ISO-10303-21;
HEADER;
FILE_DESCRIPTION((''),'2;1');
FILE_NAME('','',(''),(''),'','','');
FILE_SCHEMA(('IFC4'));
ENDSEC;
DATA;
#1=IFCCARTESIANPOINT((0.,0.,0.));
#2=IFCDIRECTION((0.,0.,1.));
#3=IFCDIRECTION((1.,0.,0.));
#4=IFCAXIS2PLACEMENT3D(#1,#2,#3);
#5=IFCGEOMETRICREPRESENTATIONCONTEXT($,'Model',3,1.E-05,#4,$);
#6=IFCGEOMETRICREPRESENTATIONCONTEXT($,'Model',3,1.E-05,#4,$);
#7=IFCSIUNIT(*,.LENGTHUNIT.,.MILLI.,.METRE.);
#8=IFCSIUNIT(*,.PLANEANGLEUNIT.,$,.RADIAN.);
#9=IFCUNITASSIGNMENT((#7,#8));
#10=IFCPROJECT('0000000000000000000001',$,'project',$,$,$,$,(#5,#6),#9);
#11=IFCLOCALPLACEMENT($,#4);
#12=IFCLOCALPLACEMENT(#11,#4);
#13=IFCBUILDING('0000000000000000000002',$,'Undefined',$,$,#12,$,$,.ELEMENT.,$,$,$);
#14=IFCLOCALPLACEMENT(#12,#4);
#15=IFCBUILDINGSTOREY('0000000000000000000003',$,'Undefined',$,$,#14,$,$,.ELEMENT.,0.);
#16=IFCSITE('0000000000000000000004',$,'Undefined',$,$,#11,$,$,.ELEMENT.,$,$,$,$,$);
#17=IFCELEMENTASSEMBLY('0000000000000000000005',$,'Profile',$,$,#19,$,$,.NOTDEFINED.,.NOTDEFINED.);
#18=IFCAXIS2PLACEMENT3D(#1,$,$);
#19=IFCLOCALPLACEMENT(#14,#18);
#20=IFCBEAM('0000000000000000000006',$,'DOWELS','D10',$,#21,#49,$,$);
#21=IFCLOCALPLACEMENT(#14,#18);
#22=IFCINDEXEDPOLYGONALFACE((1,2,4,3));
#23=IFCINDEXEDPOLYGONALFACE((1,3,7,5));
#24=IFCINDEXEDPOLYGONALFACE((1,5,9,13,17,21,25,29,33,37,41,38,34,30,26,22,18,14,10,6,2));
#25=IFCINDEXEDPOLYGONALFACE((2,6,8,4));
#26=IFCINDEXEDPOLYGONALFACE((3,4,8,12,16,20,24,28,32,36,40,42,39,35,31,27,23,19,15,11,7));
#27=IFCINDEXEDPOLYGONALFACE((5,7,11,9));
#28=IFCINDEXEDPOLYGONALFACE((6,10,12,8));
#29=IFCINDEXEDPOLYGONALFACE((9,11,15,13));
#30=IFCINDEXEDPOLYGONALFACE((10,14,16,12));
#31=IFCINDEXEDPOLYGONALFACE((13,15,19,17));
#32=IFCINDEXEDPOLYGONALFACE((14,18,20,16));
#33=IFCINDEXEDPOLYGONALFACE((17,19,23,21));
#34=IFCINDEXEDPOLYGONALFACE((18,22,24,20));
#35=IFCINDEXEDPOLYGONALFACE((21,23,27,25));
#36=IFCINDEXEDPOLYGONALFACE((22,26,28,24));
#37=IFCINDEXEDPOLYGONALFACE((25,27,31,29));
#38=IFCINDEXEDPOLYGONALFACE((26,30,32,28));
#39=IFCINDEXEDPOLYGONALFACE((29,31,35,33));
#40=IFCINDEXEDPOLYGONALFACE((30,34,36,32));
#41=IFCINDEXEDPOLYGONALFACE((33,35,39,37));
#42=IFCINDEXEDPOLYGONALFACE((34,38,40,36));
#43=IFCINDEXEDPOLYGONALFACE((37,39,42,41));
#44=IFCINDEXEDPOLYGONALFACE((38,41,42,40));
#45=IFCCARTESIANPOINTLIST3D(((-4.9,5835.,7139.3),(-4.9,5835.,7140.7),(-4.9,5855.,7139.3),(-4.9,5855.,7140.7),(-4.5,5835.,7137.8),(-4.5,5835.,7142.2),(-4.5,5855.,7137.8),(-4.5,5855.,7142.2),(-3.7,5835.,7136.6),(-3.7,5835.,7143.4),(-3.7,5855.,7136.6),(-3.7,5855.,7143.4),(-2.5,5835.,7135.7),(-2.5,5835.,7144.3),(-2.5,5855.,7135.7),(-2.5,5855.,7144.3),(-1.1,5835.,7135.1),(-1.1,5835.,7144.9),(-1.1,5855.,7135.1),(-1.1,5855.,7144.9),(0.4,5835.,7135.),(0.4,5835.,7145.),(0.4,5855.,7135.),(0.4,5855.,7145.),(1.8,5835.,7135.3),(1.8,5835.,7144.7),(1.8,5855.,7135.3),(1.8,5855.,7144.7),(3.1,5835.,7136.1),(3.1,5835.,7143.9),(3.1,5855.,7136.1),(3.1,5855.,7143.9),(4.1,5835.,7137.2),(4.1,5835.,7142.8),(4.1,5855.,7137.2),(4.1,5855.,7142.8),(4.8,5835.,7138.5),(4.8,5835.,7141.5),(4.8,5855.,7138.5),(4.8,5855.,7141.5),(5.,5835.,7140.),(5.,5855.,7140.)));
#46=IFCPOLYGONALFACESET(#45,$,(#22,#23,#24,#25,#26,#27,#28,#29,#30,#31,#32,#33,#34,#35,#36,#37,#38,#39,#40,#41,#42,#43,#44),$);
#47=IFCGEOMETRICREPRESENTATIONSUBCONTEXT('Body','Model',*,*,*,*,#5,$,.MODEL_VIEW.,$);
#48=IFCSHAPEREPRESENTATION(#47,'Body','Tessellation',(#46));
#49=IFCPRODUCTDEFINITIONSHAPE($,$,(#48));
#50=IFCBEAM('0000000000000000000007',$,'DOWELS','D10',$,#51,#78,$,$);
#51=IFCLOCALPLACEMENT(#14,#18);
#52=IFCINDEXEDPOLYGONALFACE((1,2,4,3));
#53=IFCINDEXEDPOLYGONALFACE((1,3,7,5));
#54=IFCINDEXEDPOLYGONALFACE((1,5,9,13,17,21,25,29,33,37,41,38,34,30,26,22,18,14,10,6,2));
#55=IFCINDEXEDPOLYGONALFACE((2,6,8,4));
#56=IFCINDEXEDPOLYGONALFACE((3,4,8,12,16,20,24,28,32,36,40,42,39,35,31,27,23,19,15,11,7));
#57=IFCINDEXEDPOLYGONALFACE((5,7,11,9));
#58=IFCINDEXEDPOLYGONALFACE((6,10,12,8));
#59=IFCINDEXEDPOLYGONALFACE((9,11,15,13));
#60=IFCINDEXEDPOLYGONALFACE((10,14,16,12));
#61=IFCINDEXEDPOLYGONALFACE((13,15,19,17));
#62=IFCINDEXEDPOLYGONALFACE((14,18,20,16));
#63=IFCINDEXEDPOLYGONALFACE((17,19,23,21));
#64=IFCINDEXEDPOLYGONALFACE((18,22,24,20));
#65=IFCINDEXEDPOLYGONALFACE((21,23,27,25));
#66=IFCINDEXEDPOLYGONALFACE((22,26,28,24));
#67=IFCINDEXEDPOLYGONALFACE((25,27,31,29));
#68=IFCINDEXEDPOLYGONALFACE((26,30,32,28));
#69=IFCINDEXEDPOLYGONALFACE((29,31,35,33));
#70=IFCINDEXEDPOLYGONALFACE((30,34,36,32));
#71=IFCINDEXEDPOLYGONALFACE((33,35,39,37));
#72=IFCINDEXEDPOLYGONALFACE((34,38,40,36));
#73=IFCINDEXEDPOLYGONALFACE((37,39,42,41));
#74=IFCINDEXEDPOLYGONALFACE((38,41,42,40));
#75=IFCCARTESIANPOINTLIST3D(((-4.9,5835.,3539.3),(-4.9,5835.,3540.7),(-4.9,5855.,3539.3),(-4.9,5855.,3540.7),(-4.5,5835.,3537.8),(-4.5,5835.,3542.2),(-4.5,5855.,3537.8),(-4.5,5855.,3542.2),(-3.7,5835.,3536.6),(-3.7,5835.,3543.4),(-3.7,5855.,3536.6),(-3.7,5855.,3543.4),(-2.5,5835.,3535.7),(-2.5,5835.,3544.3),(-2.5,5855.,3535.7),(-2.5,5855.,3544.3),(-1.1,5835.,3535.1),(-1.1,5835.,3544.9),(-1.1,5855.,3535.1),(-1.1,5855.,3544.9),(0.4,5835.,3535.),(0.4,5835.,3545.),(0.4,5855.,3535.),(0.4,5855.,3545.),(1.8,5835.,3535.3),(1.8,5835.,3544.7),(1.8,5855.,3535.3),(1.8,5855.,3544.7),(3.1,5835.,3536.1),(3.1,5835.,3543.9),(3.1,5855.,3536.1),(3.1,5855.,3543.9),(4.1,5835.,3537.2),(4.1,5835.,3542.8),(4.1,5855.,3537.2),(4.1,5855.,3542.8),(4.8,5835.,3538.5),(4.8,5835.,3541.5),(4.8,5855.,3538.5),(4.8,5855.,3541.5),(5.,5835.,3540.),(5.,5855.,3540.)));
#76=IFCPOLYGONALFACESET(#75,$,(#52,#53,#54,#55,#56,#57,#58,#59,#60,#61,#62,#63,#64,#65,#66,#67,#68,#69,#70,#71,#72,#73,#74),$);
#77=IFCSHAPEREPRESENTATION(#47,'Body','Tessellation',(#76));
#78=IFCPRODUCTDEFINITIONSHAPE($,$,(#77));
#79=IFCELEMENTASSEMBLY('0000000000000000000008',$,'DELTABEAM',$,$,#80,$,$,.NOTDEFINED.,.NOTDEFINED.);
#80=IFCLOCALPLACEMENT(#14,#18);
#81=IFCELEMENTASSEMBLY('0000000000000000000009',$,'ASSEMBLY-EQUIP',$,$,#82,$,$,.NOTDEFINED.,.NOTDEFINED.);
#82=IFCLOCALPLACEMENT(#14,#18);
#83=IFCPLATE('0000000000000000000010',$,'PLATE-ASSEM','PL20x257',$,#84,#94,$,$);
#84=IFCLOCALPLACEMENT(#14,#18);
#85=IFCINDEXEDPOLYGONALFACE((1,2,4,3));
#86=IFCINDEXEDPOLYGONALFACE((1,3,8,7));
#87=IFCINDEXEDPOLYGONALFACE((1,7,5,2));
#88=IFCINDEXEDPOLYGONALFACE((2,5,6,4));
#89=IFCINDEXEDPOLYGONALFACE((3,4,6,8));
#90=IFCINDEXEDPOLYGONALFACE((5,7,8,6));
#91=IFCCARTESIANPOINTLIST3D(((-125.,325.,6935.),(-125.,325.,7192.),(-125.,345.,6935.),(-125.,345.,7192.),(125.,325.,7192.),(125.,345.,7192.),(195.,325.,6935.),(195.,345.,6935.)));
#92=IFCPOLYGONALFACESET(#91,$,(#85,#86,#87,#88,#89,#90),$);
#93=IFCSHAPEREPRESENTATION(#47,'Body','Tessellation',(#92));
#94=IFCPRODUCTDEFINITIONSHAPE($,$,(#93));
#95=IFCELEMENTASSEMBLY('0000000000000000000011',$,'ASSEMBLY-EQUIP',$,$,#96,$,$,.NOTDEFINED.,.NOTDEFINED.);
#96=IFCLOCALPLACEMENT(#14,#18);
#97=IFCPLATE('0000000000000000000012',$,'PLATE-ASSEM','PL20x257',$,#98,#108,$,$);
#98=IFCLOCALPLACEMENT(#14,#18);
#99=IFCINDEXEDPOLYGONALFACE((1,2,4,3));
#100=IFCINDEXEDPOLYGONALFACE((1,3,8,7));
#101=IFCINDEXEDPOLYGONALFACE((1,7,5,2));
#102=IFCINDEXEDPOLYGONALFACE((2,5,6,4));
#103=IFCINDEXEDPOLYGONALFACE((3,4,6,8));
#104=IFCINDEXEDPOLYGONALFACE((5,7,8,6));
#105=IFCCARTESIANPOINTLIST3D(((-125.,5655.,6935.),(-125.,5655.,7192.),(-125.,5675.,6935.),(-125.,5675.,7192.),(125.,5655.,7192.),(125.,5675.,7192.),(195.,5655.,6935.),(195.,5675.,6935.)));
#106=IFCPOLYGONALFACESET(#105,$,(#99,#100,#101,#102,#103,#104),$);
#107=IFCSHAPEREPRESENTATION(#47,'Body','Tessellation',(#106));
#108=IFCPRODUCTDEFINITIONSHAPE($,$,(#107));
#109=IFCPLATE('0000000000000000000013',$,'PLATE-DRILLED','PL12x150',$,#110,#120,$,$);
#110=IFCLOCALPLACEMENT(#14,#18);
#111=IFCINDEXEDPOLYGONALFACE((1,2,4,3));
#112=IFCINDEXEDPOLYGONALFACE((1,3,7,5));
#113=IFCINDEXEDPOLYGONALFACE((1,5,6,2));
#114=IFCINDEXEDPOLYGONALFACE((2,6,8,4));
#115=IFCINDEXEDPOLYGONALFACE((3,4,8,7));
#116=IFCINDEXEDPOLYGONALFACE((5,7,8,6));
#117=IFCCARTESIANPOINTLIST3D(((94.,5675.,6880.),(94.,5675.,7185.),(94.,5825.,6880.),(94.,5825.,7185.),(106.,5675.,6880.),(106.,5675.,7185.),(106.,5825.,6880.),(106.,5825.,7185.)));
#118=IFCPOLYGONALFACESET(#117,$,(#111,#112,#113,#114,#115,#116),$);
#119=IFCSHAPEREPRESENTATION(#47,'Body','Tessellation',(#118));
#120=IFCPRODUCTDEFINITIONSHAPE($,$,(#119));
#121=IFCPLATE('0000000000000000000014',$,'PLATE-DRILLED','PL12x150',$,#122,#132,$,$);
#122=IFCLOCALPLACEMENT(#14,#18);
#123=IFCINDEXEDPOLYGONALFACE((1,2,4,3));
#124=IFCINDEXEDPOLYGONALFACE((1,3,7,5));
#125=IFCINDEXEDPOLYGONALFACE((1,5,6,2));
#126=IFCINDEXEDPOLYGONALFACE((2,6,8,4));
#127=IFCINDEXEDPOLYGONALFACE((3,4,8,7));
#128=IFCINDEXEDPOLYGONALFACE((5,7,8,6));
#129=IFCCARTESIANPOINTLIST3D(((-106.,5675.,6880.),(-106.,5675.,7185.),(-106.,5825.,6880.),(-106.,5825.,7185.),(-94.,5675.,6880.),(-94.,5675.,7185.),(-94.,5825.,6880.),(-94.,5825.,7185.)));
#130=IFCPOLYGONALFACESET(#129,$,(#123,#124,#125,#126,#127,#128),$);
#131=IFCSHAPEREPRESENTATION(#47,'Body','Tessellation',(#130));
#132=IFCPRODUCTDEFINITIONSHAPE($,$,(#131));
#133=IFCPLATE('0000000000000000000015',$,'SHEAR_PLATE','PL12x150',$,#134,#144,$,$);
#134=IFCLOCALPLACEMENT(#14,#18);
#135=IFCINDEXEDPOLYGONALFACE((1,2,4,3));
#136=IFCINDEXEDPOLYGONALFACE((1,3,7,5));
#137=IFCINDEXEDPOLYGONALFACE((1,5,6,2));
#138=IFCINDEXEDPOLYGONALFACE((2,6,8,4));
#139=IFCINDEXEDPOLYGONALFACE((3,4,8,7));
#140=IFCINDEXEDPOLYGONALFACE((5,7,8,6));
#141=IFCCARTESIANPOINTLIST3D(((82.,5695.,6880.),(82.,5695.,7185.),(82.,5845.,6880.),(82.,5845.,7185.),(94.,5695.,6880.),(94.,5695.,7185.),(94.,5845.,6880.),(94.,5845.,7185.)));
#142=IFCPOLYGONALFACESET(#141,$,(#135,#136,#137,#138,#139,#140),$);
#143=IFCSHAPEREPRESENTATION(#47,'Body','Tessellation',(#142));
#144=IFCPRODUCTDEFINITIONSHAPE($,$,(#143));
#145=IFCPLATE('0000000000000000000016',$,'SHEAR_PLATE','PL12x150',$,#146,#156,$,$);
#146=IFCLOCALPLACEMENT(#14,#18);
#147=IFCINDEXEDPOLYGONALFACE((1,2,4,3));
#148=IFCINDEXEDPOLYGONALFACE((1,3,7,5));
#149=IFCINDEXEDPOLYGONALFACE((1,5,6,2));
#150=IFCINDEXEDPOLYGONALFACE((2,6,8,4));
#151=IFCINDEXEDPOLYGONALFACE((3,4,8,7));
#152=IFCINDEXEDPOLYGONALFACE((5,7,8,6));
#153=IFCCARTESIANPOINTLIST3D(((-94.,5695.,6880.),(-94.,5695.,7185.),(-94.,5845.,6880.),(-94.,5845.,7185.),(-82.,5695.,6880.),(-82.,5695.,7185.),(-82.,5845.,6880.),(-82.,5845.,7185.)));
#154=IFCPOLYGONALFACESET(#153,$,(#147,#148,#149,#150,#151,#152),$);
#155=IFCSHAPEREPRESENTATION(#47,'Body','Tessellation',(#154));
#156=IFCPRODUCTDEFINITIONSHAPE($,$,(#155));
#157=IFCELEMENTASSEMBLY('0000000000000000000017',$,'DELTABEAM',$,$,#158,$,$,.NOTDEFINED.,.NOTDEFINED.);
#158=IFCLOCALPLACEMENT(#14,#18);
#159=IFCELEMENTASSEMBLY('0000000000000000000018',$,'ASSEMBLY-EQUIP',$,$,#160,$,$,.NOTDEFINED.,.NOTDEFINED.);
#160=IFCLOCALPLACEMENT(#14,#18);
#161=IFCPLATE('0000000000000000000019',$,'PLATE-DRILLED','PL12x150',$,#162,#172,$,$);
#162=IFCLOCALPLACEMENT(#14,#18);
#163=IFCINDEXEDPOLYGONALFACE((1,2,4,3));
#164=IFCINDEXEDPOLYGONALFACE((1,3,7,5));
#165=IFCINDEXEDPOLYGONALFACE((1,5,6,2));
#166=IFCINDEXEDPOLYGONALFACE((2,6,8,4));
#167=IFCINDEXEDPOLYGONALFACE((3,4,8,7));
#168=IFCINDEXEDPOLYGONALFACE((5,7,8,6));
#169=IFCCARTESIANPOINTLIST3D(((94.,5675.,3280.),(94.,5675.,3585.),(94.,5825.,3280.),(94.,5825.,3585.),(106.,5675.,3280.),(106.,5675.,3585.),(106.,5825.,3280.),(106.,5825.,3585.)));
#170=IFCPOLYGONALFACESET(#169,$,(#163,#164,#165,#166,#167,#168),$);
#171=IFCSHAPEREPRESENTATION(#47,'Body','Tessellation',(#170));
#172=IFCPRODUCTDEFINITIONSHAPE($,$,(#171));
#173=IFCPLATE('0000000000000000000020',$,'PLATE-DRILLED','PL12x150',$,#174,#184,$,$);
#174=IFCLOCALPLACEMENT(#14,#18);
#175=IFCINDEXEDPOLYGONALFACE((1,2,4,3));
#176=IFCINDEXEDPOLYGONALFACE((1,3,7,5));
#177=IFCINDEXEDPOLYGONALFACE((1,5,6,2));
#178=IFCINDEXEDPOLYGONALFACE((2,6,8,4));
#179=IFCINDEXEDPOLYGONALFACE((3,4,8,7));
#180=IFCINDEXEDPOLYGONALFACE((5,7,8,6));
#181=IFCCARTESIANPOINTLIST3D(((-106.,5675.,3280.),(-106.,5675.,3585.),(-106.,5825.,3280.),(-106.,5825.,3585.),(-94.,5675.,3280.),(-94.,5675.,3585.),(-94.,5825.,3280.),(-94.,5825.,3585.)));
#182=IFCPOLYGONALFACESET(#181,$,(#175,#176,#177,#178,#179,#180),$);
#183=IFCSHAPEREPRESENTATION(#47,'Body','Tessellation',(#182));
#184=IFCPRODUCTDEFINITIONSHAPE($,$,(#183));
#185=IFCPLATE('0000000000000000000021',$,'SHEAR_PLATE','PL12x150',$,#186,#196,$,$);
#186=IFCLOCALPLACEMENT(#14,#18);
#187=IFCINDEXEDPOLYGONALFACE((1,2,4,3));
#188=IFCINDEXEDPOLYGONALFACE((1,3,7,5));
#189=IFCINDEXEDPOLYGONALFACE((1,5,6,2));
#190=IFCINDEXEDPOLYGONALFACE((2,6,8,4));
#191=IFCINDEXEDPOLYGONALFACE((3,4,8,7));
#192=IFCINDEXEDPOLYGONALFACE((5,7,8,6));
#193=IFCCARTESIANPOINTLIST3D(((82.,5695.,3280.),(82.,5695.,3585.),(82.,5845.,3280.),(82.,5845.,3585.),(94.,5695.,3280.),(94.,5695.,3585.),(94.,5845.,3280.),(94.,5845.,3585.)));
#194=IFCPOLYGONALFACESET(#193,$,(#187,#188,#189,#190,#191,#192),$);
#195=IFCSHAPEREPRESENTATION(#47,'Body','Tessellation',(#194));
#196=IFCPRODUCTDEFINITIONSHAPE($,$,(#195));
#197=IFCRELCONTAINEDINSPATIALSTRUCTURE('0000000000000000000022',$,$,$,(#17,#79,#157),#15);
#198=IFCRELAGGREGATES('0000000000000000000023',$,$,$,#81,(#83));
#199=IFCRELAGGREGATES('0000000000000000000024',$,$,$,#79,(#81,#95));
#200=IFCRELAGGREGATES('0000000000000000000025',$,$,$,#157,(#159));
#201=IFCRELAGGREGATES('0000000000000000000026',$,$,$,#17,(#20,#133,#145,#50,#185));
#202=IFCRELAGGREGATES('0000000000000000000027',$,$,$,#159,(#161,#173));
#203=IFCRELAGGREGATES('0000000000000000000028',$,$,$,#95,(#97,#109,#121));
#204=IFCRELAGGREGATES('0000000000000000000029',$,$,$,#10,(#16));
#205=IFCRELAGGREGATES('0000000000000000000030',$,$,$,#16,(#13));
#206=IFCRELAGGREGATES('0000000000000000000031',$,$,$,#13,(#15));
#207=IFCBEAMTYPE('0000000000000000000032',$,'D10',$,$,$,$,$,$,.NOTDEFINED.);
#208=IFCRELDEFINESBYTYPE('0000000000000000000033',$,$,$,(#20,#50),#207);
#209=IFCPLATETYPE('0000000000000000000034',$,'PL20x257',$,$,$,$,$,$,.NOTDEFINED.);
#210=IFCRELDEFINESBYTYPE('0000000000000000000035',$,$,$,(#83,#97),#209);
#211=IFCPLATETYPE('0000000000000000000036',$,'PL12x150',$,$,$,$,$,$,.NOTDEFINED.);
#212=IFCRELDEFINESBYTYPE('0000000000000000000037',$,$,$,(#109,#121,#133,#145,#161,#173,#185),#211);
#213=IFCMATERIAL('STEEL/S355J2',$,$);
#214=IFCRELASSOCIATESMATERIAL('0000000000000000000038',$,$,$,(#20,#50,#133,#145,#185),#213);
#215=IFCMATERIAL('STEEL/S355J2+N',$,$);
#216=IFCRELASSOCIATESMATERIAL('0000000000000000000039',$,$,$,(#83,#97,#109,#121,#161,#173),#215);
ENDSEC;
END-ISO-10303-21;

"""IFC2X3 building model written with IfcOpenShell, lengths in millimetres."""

from ifc_helpers import new_model, si_unit, frame, origin_with_axes, origin_2d_with_axis, place, context, subcontext, project, spatial, polyline, circle, outline, extrude, material, type_object, element, aggregate, save


model = new_model("IFC2X3")

# Units and contexts
model_context_1 = context("Model", 3, precision=1e-05, world=origin_with_axes())
model_context_2 = context("Model", 3, precision=1e-05, world=origin_with_axes())
body_context = subcontext(model_context_1, "Body", "Model", "MODEL_VIEW")
ifc_project = project(units=[si_unit("LENGTHUNIT", "METRE", prefix="MILLI"), si_unit("PLANEANGLEUNIT", "RADIAN")], contexts=[model_context_1, model_context_2])

# Site, building, storey
site_placement = place(None, origin_with_axes())
site = spatial("IfcSite", under=ifc_project, at=site_placement, Name="Undefined", CompositionType="ELEMENT")
building_placement = place(site_placement, origin_with_axes())
building = spatial("IfcBuilding", under=site, at=building_placement, Name="Undefined", CompositionType="ELEMENT")
storey_placement = place(building_placement, origin_with_axes())
storey = spatial("IfcBuildingStorey", under=building, at=storey_placement, Name="Undefined", CompositionType="ELEMENT", Elevation=0.0)

# Element assembly, beams
assembly_1_placement = place(storey_placement, origin_with_axes())
assembly_1 = element("IfcElementAssembly", 1, at=assembly_1_placement, inside=storey, Name="Profile", AssemblyPlace="NOTDEFINED", PredefinedType="NOTDEFINED")
ifc_material_1 = material(Name="STEEL/S355J2")
beam_type_1 = type_object("IfcBeamType", Name="D10", PredefinedType="NOTDEFINED")
beam_1_placement = place(assembly_1_placement, frame((0.0, 5835.0, 7140.0), z_axis=(0.0, 0.0, 1.0), x_axis=(0.0, 1.0, 0.0)))
beam_1 = element("IfcBeam", 2, at=beam_1_placement, type_object=beam_type_1, material=ifc_material_1, Name="DOWELS", Description="D10", context=body_context, shape_type="SweptSolid", body=[
    extrude(circle(Radius=5.0, at=origin_2d_with_axis()), frame((20.0, 0.0, 0.0), z_axis=(-1.0, 0.0, 0.0), x_axis=(0.0, -1.0, 0.0)), (0.0, 0.0, 1.0), 20.0),
])
beam_2_placement = place(assembly_1_placement, frame((0.0, 5835.0, 3540.0), z_axis=(0.0, 0.0, 1.0), x_axis=(0.0, 1.0, 0.0)))
beam_2 = element("IfcBeam", 3, at=beam_2_placement, type_object=beam_type_1, material=ifc_material_1, Name="DOWELS", Description="D10", context=body_context, shape_type="SweptSolid", body=[
    extrude(circle(Radius=5.0, at=origin_2d_with_axis()), frame((20.0, 0.0, 0.0), z_axis=(-1.0, 0.0, 0.0), x_axis=(0.0, -1.0, 0.0)), (0.0, 0.0, 1.0), 20.0),
])

# Element assemblies, plates
assembly_2_placement = place(storey_placement, origin_with_axes())
assembly_2 = element("IfcElementAssembly", 4, at=assembly_2_placement, inside=storey, Name="DELTABEAM", AssemblyPlace="NOTDEFINED", PredefinedType="NOTDEFINED")
assembly_3_placement = place(assembly_2_placement, origin_with_axes())
assembly_3 = element("IfcElementAssembly", 5, at=assembly_3_placement, Name="ASSEMBLY-EQUIP", AssemblyPlace="NOTDEFINED", PredefinedType="NOTDEFINED")
ifc_material_2 = material(Name="STEEL/S355J2+N")
plate_type_1 = type_object("IfcPlateType", Name="PL20x257", PredefinedType="NOTDEFINED")
plate_1_placement = place(assembly_3_placement, frame((195.0, 335.0, 6935.0), z_axis=(0.0, 1.0, 0.0), x_axis=(-1.0, 0.0, 0.0)))
plate_1 = element("IfcPlate", 6, at=plate_1_placement, type_object=plate_type_1, material=ifc_material_2, Name="PLATE-ASSEM", Description="PL20x257", context=body_context, shape_type="SweptSolid", body=[
    extrude(outline(polyline([(0.0, 0.0), (320.0, 0.0), (320.0, 257.0), (70.0, 257.0), (0.0, 0.0)])), frame((0.0, 0.0, -10.0), z_axis=(0.0, 0.0, 1.0), x_axis=(1.0, 0.0, 0.0)), (0.0, 0.0, 1.0), 20.0),
])
aggregate(assembly_3, [plate_1])
assembly_4_placement = place(assembly_2_placement, origin_with_axes())
assembly_4 = element("IfcElementAssembly", 7, at=assembly_4_placement, Name="ASSEMBLY-EQUIP", AssemblyPlace="NOTDEFINED", PredefinedType="NOTDEFINED")
aggregate(assembly_2, [assembly_3, assembly_4])
plate_2_placement = place(assembly_4_placement, frame((-125.0, 5665.0, 6935.0), z_axis=(0.0, -1.0, 0.0), x_axis=(1.0, 0.0, 0.0)))
plate_2 = element("IfcPlate", 8, at=plate_2_placement, type_object=plate_type_1, material=ifc_material_2, Name="PLATE-ASSEM", Description="PL20x257", context=body_context, shape_type="SweptSolid", body=[
    extrude(outline(polyline([(0.0, 0.0), (320.0, 0.0), (250.0, 257.0), (0.0, 257.0), (0.0, 0.0)])), frame((0.0, 0.0, -10.0), z_axis=(0.0, 0.0, 1.0), x_axis=(1.0, 0.0, 0.0)), (0.0, 0.0, 1.0), 20.0),
])
plate_type_2 = type_object("IfcPlateType", Name="PL12x150", PredefinedType="NOTDEFINED")
plate_3_placement = place(assembly_4_placement, frame((100.0, 5675.0, 7185.0), z_axis=(-1.0, 0.0, 0.0), x_axis=(0.0, 1.0, 0.0)))
plate_3 = element("IfcPlate", 9, at=plate_3_placement, type_object=plate_type_2, material=ifc_material_2, Name="PLATE-DRILLED", Description="PL12x150", context=body_context, shape_type="SweptSolid", body=[
    extrude(outline(polyline([(0.0, 0.0), (150.0, 0.0), (150.0, 0.0), (150.0, 305.0), (150.0, 305.0), (0.0, 305.0), (0.0, 305.0), (0.0, 0.0)])), frame((0.0, 0.0, -6.0), z_axis=(0.0, 0.0, 1.0), x_axis=(1.0, 0.0, 0.0)), (0.0, 0.0, 1.0), 12.0),
])
plate_4_placement = place(assembly_4_placement, frame((-100.0, 5675.0, 7185.0), z_axis=(-1.0, 0.0, 0.0), x_axis=(0.0, 1.0, 0.0)))
plate_4 = element("IfcPlate", 10, at=plate_4_placement, type_object=plate_type_2, material=ifc_material_2, Name="PLATE-DRILLED", Description="PL12x150", context=body_context, shape_type="SweptSolid", body=[
    extrude(outline(polyline([(0.0, 0.0), (150.0, 0.0), (150.0, 0.0), (150.0, 305.0), (150.0, 305.0), (0.0, 305.0), (0.0, 305.0), (0.0, 0.0)])), frame((0.0, 0.0, -6.0), z_axis=(0.0, 0.0, 1.0), x_axis=(1.0, 0.0, 0.0)), (0.0, 0.0, 1.0), 12.0),
])

# Plates
plate_5_placement = place(assembly_1_placement, frame((88.0, 5845.0, 7185.0), z_axis=(1.0, 0.0, 0.0), x_axis=(0.0, -1.0, 0.0)))
plate_5 = element("IfcPlate", 11, at=plate_5_placement, type_object=plate_type_2, material=ifc_material_1, Name="SHEAR_PLATE", Description="PL12x150", context=body_context, shape_type="SweptSolid", body=[
    extrude(outline(polyline([(0.0, 0.0), (150.0, 0.0), (150.0, 0.0), (150.0, 305.0), (150.0, 305.0), (0.0, 305.0), (0.0, 305.0), (0.0, 0.0)])), frame((0.0, 0.0, -6.0), z_axis=(0.0, 0.0, 1.0), x_axis=(1.0, 0.0, 0.0)), (0.0, 0.0, 1.0), 12.0),
])
plate_6_placement = place(assembly_1_placement, frame((-88.0, 5845.0, 7185.0), z_axis=(1.0, 0.0, 0.0), x_axis=(0.0, -1.0, 0.0)))
plate_6 = element("IfcPlate", 12, at=plate_6_placement, type_object=plate_type_2, material=ifc_material_1, Name="SHEAR_PLATE", Description="PL12x150", context=body_context, shape_type="SweptSolid", body=[
    extrude(outline(polyline([(0.0, 0.0), (150.0, 0.0), (150.0, 0.0), (150.0, 305.0), (150.0, 305.0), (0.0, 305.0), (0.0, 305.0), (0.0, 0.0)])), frame((0.0, 0.0, -6.0), z_axis=(0.0, 0.0, 1.0), x_axis=(1.0, 0.0, 0.0)), (0.0, 0.0, 1.0), 12.0),
])

# Element assemblies, plates
assembly_5_placement = place(storey_placement, origin_with_axes())
assembly_5 = element("IfcElementAssembly", 13, at=assembly_5_placement, inside=storey, Name="DELTABEAM", AssemblyPlace="NOTDEFINED", PredefinedType="NOTDEFINED")
assembly_6_placement = place(assembly_5_placement, origin_with_axes())
assembly_6 = element("IfcElementAssembly", 14, at=assembly_6_placement, Name="ASSEMBLY-EQUIP", AssemblyPlace="NOTDEFINED", PredefinedType="NOTDEFINED")
aggregate(assembly_5, [assembly_6])
plate_7_placement = place(assembly_6_placement, frame((100.0, 5675.0, 3585.0), z_axis=(-1.0, 0.0, 0.0), x_axis=(0.0, 1.0, 0.0)))
plate_7 = element("IfcPlate", 15, at=plate_7_placement, type_object=plate_type_2, material=ifc_material_2, Name="PLATE-DRILLED", Description="PL12x150", context=body_context, shape_type="SweptSolid", body=[
    extrude(outline(polyline([(0.0, 0.0), (150.0, 0.0), (150.0, 0.0), (150.0, 305.0), (150.0, 305.0), (0.0, 305.0), (0.0, 305.0), (0.0, 0.0)])), frame((0.0, 0.0, -6.0), z_axis=(0.0, 0.0, 1.0), x_axis=(1.0, 0.0, 0.0)), (0.0, 0.0, 1.0), 12.0),
])
plate_8_placement = place(assembly_6_placement, frame((-100.0, 5675.0, 3585.0), z_axis=(-1.0, 0.0, 0.0), x_axis=(0.0, 1.0, 0.0)))
plate_8 = element("IfcPlate", 16, at=plate_8_placement, type_object=plate_type_2, material=ifc_material_2, Name="PLATE-DRILLED", Description="PL12x150", context=body_context, shape_type="SweptSolid", body=[
    extrude(outline(polyline([(0.0, 0.0), (150.0, 0.0), (150.0, 0.0), (150.0, 305.0), (150.0, 305.0), (0.0, 305.0), (0.0, 305.0), (0.0, 0.0)])), frame((0.0, 0.0, -6.0), z_axis=(0.0, 0.0, 1.0), x_axis=(1.0, 0.0, 0.0)), (0.0, 0.0, 1.0), 12.0),
])

# Plate
plate_9_placement = place(assembly_1_placement, frame((88.0, 5845.0, 3585.0), z_axis=(1.0, 0.0, 0.0), x_axis=(0.0, -1.0, 0.0)))
plate_9 = element("IfcPlate", 17, at=plate_9_placement, type_object=plate_type_2, material=ifc_material_1, Name="SHEAR_PLATE", Description="PL12x150", context=body_context, shape_type="SweptSolid", body=[
    extrude(outline(polyline([(0.0, 0.0), (150.0, 0.0), (150.0, 0.0), (150.0, 305.0), (150.0, 305.0), (0.0, 305.0), (0.0, 305.0), (0.0, 0.0)])), frame((0.0, 0.0, -6.0), z_axis=(0.0, 0.0, 1.0), x_axis=(1.0, 0.0, 0.0)), (0.0, 0.0, 1.0), 12.0),
])
aggregate(assembly_1, [beam_1, plate_5, plate_6, beam_2, plate_9])

aggregate(assembly_6, [plate_7, plate_8])
aggregate(assembly_4, [plate_2, plate_3, plate_4])

save(model, "model.ifc")
